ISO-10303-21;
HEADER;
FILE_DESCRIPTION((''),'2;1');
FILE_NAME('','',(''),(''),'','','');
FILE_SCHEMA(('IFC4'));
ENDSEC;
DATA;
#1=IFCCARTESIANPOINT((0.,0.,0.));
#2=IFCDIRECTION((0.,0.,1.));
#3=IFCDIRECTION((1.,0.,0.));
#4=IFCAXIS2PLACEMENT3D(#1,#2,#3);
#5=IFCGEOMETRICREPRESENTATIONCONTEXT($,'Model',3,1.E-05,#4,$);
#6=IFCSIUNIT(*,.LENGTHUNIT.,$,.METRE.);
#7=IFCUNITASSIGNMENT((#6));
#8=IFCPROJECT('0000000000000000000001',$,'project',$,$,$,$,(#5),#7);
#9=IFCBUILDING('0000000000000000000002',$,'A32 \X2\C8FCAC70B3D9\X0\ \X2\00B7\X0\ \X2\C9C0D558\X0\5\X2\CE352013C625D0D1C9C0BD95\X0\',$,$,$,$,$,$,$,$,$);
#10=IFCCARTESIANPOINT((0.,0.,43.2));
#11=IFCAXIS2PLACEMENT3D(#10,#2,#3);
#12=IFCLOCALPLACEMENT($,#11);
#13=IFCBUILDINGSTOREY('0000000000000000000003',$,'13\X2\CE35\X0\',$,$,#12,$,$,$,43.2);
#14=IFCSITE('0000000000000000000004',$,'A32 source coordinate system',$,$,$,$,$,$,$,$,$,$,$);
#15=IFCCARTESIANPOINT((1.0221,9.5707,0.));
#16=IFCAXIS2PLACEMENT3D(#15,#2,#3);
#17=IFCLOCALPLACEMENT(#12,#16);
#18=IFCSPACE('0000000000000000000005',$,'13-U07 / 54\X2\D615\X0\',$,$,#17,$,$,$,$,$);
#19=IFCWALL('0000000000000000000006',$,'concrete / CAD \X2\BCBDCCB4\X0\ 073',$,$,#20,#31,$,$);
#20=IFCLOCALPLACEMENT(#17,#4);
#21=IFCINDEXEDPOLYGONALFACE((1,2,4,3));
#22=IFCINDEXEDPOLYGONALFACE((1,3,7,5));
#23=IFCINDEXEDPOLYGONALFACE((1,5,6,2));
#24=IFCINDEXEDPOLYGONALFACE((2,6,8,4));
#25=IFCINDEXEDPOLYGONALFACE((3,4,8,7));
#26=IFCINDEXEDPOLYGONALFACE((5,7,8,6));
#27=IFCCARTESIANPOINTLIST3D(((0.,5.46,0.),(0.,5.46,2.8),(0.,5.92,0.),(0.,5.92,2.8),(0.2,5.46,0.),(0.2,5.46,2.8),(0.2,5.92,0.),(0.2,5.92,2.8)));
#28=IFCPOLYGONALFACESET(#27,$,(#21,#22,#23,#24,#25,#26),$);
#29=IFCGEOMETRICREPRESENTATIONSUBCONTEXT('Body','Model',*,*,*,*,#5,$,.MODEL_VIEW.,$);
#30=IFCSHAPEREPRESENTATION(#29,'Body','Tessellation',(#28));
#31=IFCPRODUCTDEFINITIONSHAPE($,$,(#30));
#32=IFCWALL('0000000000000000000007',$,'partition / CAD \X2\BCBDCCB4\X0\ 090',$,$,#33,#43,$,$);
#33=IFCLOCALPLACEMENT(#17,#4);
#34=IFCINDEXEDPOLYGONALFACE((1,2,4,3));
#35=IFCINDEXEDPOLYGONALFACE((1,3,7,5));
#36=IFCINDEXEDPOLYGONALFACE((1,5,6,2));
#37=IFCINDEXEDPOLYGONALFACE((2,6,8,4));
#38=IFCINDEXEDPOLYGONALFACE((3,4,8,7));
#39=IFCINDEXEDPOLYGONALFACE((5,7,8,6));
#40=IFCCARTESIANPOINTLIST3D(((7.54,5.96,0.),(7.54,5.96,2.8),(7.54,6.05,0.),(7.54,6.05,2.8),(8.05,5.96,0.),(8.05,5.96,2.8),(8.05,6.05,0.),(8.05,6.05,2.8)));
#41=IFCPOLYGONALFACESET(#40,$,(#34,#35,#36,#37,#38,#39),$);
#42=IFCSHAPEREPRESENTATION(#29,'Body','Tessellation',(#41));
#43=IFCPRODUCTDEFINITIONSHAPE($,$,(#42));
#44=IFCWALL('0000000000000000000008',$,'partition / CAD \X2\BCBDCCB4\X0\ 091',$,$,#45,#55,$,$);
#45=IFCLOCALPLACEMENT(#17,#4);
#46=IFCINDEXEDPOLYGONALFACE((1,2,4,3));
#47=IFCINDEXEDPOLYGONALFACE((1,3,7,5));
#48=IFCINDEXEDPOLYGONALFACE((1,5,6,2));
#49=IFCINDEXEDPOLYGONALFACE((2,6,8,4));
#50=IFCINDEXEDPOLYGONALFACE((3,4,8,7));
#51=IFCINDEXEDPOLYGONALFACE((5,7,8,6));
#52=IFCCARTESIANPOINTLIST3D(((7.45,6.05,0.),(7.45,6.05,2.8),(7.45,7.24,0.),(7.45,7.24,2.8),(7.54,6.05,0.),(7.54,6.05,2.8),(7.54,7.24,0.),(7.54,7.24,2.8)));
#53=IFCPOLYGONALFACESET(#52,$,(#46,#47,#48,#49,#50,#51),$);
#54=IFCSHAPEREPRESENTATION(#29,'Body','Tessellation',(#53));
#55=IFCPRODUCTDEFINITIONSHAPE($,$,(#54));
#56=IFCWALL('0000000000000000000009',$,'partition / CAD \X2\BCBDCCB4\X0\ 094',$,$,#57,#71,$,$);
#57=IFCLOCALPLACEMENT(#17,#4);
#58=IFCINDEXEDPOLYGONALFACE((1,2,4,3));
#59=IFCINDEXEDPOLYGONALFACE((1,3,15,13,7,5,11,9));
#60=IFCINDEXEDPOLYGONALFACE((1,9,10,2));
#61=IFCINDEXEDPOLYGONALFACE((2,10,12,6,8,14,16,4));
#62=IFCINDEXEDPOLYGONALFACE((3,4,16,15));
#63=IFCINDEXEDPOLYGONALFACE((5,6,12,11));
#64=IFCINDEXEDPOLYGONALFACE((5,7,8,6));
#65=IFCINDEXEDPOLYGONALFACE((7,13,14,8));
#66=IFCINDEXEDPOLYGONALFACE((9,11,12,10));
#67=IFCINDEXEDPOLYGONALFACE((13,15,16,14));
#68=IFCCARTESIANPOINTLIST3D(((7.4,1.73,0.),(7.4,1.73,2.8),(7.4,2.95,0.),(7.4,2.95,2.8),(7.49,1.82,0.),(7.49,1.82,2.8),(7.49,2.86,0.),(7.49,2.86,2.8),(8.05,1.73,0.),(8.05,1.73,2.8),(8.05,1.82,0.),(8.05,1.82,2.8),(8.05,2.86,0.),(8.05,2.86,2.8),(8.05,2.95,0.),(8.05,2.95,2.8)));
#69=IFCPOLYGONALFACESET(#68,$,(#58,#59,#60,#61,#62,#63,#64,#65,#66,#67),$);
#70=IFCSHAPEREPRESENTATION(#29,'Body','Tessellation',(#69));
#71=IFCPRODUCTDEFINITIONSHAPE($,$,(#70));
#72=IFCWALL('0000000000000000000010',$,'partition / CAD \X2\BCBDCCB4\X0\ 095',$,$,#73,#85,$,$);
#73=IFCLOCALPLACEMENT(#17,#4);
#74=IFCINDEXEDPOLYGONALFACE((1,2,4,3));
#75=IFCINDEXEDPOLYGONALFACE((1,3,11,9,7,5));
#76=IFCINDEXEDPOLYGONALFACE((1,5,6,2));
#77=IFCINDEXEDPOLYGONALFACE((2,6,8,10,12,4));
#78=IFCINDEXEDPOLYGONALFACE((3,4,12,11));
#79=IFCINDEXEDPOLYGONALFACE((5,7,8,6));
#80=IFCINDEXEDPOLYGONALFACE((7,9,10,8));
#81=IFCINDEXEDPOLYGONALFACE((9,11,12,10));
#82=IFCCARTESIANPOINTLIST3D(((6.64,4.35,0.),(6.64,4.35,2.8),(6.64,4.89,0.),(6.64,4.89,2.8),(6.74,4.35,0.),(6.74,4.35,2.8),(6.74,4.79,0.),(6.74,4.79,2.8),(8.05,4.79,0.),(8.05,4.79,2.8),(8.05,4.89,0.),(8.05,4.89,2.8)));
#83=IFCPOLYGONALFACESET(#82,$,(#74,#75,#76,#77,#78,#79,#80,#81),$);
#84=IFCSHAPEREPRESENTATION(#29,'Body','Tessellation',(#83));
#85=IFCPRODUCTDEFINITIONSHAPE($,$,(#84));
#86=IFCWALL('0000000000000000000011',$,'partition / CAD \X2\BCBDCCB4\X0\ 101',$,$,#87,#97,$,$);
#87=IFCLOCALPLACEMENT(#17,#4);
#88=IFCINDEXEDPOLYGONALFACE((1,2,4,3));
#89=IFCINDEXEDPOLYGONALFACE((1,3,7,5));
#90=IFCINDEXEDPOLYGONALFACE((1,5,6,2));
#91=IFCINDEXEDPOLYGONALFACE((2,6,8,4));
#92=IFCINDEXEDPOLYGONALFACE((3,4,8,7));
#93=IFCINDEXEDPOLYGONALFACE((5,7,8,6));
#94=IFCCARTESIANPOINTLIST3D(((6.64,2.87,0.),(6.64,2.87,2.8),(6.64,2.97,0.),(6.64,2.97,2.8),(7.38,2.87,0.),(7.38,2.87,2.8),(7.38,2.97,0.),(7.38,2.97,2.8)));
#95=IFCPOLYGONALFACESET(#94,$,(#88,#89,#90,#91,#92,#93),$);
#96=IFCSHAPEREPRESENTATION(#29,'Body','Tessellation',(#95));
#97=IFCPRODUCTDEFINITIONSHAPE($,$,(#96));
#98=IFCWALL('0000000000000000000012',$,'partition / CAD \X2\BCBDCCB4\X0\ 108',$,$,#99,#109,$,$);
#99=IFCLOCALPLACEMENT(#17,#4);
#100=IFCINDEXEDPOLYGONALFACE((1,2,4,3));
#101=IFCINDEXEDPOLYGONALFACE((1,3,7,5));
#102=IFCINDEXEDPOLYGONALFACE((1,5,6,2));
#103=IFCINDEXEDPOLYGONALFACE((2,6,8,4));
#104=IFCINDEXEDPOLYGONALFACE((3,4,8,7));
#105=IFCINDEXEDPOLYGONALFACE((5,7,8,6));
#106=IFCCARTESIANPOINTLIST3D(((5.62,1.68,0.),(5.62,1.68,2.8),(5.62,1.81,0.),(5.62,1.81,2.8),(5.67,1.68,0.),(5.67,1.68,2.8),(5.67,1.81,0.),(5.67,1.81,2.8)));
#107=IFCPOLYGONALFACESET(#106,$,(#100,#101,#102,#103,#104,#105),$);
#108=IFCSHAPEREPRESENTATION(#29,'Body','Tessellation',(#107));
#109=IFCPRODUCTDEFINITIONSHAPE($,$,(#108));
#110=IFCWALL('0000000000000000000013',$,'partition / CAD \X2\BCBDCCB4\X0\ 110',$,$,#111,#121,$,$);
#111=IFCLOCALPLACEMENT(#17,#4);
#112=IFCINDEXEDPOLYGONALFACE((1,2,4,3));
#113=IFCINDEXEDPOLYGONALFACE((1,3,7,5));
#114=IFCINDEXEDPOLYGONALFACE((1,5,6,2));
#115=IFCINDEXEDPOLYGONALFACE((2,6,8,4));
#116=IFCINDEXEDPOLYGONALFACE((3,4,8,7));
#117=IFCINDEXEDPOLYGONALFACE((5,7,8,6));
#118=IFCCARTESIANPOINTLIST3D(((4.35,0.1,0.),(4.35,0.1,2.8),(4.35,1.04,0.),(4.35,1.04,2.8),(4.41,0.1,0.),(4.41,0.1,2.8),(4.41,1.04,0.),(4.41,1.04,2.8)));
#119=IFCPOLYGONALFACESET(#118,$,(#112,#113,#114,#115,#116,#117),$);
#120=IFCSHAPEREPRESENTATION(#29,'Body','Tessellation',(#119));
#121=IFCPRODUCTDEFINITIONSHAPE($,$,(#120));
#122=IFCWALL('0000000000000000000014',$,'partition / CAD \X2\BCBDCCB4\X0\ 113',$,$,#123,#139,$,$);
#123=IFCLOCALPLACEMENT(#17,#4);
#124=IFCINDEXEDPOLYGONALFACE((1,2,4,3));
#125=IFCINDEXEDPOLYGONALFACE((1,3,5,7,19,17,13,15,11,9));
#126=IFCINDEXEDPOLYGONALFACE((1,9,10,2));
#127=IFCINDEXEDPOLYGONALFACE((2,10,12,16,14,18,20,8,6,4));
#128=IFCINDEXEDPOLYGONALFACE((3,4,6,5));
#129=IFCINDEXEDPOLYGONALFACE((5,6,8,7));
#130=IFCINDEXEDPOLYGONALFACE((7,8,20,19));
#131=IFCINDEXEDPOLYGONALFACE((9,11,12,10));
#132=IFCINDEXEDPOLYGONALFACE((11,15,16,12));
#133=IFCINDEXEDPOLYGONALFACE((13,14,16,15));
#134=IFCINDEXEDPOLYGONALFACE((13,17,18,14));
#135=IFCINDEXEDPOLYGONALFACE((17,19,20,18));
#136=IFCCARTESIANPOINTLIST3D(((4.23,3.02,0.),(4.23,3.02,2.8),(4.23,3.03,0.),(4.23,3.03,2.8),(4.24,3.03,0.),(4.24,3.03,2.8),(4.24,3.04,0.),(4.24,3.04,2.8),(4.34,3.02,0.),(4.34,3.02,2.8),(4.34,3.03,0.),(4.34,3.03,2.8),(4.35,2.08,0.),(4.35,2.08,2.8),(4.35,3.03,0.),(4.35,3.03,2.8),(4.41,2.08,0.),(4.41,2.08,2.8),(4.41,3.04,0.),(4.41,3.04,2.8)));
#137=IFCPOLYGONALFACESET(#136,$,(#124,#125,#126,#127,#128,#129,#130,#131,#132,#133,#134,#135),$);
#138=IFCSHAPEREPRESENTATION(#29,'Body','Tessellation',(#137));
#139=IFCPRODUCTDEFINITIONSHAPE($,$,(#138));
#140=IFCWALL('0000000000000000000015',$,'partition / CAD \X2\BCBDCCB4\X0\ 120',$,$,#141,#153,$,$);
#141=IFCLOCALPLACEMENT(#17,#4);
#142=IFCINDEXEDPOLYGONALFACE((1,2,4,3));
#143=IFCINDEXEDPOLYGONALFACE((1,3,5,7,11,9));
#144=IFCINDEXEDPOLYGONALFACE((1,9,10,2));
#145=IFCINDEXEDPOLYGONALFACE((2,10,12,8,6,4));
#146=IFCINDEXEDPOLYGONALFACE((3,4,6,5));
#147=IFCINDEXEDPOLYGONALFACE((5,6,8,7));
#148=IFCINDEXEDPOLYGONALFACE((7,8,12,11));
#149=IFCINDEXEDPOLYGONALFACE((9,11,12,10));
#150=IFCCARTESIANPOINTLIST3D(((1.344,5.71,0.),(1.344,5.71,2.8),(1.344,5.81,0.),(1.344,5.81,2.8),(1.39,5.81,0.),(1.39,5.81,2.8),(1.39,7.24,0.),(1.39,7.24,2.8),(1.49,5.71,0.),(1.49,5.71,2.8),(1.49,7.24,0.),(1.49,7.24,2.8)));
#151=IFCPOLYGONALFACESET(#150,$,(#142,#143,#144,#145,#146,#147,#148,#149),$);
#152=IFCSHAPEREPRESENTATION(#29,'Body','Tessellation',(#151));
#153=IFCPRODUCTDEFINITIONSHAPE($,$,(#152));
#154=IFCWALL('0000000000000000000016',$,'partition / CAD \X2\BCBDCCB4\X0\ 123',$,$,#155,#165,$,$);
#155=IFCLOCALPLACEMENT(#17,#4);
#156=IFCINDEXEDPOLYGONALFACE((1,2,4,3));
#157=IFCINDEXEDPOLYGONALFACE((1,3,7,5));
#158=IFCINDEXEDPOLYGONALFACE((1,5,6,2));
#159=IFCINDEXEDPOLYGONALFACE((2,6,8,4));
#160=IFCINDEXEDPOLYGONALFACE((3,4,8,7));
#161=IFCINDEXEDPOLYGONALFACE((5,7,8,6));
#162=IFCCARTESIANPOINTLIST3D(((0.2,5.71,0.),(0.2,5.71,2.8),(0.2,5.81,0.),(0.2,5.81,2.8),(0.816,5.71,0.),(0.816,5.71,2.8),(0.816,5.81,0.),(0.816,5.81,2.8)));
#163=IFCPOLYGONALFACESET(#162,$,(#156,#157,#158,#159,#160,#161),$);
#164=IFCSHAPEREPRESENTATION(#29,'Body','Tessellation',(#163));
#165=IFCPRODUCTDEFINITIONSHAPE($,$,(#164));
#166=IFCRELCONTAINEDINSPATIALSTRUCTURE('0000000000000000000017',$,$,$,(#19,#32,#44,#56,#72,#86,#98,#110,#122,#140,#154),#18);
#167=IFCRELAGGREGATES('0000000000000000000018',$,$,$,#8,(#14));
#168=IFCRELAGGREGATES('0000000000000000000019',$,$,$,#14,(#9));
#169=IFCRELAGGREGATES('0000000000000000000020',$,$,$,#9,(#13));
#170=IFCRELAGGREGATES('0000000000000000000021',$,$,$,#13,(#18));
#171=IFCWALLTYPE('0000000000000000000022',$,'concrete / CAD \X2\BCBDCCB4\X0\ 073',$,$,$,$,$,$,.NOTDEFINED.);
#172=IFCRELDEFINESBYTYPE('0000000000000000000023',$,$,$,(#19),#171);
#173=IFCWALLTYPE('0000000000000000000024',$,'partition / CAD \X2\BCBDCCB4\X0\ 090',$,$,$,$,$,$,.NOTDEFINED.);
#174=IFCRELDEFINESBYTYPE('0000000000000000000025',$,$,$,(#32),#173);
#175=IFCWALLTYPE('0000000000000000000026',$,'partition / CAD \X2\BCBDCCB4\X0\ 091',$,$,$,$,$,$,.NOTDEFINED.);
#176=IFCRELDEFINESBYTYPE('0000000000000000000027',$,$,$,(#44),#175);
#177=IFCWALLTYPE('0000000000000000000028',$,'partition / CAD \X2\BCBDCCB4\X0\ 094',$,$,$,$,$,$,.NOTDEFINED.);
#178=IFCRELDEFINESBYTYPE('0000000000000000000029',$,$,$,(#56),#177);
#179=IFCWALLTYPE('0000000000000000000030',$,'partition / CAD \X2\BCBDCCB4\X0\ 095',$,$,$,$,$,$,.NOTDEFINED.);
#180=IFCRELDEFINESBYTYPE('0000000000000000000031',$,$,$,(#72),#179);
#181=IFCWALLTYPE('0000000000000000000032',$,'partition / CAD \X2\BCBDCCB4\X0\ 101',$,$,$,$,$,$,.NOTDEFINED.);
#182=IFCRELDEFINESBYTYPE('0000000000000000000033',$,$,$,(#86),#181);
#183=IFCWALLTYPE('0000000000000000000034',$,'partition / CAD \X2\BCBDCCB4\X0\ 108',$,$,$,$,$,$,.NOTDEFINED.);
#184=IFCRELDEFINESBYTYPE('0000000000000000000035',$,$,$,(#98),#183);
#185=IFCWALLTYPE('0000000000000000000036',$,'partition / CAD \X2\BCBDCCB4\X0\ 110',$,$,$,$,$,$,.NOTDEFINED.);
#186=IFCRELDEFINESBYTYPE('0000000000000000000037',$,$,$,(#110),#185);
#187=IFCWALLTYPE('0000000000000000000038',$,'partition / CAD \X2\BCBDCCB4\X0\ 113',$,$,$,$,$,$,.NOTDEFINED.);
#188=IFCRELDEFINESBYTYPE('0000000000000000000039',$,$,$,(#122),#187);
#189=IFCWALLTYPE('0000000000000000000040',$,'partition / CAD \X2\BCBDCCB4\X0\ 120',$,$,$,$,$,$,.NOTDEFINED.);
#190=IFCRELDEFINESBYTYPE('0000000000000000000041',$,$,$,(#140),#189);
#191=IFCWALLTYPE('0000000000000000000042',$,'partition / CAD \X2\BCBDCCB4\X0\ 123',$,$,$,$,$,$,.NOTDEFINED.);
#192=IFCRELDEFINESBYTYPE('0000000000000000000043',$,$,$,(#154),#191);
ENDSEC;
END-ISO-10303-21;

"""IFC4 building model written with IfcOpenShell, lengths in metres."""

from ifc_helpers import new_model, si_unit, frame, origin, origin_with_axes, place, context, subcontext, project, spatial, polyline, outline, extrude, source, transform, mapped, type_object, type_shapes, element, save


model = new_model("IFC4")

# Units and contexts
model_context = context("Model", 3, precision=1e-05, world=origin_with_axes())
body_context = subcontext(model_context, "Body", "Model", "MODEL_VIEW")
ifc_project = project(units=[si_unit("LENGTHUNIT", "METRE")], contexts=[model_context])

# Site, building, storey, space
site = spatial("IfcSite", under=ifc_project, Name="A32 source coordinate system")
building = spatial("IfcBuilding", under=site, Name="A32 주거동 · 지하5층–옥탑지붕")
storey_placement = place(None, frame((0.0, 0.0, 43.2), z_axis=(0.0, 0.0, 1.0), x_axis=(1.0, 0.0, 0.0)))
storey = spatial("IfcBuildingStorey", under=building, at=storey_placement, Name="13층", Elevation=43.2)
space_1_placement = place(storey_placement, frame((1.0221, 9.5707, 0.0), z_axis=(0.0, 0.0, 1.0), x_axis=(1.0, 0.0, 0.0)))
space_1 = spatial("IfcSpace", under=storey, at=space_1_placement, Name="13-U07 / 54형")

# Walls
wall_type_1 = type_object("IfcWallType", Name="concrete / CAD 벽체 073", PredefinedType="NOTDEFINED")
shared_shape_1 = source(origin(), body_context, "Body", "SweptSolid", [
    extrude(outline(polyline([(0.2, 5.92), (0.2, 5.46), (0.0, 5.46), (0.0, 5.92), (0.2, 5.92)])), origin(), (0.0, 0.0, 1.0), 2.8),
])
type_shapes(wall_type_1, [shared_shape_1])
wall_1_placement = place(space_1_placement, origin_with_axes())
element("IfcWall", 1, at=wall_1_placement, inside=space_1, type_object=wall_type_1, Name="concrete / CAD 벽체 073", context=body_context, shape_type="MappedRepresentation", body=[
    mapped(shared_shape_1, transform((0.0, 0.0, 0.0), scale=1.0)),
])
wall_type_2 = type_object("IfcWallType", Name="partition / CAD 벽체 090", PredefinedType="NOTDEFINED")
shared_shape_2 = source(origin(), body_context, "Body", "SweptSolid", [
    extrude(outline(polyline([(7.54, 5.96), (7.54, 6.05), (8.05, 6.05), (8.05, 5.96), (7.54, 5.96)])), origin(), (0.0, 0.0, 1.0), 2.8),
])
type_shapes(wall_type_2, [shared_shape_2])
wall_2_placement = place(space_1_placement, origin_with_axes())
element("IfcWall", 2, at=wall_2_placement, inside=space_1, type_object=wall_type_2, Name="partition / CAD 벽체 090", context=body_context, shape_type="MappedRepresentation", body=[
    mapped(shared_shape_2, transform((0.0, 0.0, 0.0), scale=1.0)),
])
wall_type_3 = type_object("IfcWallType", Name="partition / CAD 벽체 091", PredefinedType="NOTDEFINED")
shared_shape_3 = source(origin(), body_context, "Body", "SweptSolid", [
    extrude(outline(polyline([(7.54, 6.05), (7.45, 6.05), (7.45, 7.24), (7.54, 7.24), (7.54, 6.05)])), origin(), (0.0, 0.0, 1.0), 2.8),
])
type_shapes(wall_type_3, [shared_shape_3])
wall_3_placement = place(space_1_placement, origin_with_axes())
element("IfcWall", 3, at=wall_3_placement, inside=space_1, type_object=wall_type_3, Name="partition / CAD 벽체 091", context=body_context, shape_type="MappedRepresentation", body=[
    mapped(shared_shape_3, transform((0.0, 0.0, 0.0), scale=1.0)),
])
wall_type_4 = type_object("IfcWallType", Name="partition / CAD 벽체 094", PredefinedType="NOTDEFINED")
shared_shape_4 = source(origin(), body_context, "Body", "SweptSolid", [
    extrude(outline(polyline([(8.05, 1.73), (7.4, 1.73), (7.4, 2.95), (8.05, 2.95), (8.05, 2.86), (7.49, 2.86), (7.49, 1.82), (8.05, 1.82), (8.05, 1.73)])), origin(), (0.0, 0.0, 1.0), 2.8),
])
type_shapes(wall_type_4, [shared_shape_4])
wall_4_placement = place(space_1_placement, origin_with_axes())
element("IfcWall", 4, at=wall_4_placement, inside=space_1, type_object=wall_type_4, Name="partition / CAD 벽체 094", context=body_context, shape_type="MappedRepresentation", body=[
    mapped(shared_shape_4, transform((0.0, 0.0, 0.0), scale=1.0)),
])
wall_type_5 = type_object("IfcWallType", Name="partition / CAD 벽체 095", PredefinedType="NOTDEFINED")
shared_shape_5 = source(origin(), body_context, "Body", "SweptSolid", [
    extrude(outline(polyline([(6.64, 4.89), (8.05, 4.89), (8.05, 4.79), (6.74, 4.79), (6.74, 4.35), (6.64, 4.35), (6.64, 4.89)])), origin(), (0.0, 0.0, 1.0), 2.8),
])
type_shapes(wall_type_5, [shared_shape_5])
wall_5_placement = place(space_1_placement, origin_with_axes())
element("IfcWall", 5, at=wall_5_placement, inside=space_1, type_object=wall_type_5, Name="partition / CAD 벽체 095", context=body_context, shape_type="MappedRepresentation", body=[
    mapped(shared_shape_5, transform((0.0, 0.0, 0.0), scale=1.0)),
])
wall_type_6 = type_object("IfcWallType", Name="partition / CAD 벽체 101", PredefinedType="NOTDEFINED")
shared_shape_6 = source(origin(), body_context, "Body", "SweptSolid", [
    extrude(outline(polyline([(7.38, 2.97), (7.38, 2.87), (6.64, 2.87), (6.64, 2.97), (7.38, 2.97)])), origin(), (0.0, 0.0, 1.0), 2.8),
])
type_shapes(wall_type_6, [shared_shape_6])
wall_6_placement = place(space_1_placement, origin_with_axes())
element("IfcWall", 6, at=wall_6_placement, inside=space_1, type_object=wall_type_6, Name="partition / CAD 벽체 101", context=body_context, shape_type="MappedRepresentation", body=[
    mapped(shared_shape_6, transform((0.0, 0.0, 0.0), scale=1.0)),
])
wall_type_7 = type_object("IfcWallType", Name="partition / CAD 벽체 108", PredefinedType="NOTDEFINED")
shared_shape_7 = source(origin(), body_context, "Body", "SweptSolid", [
    extrude(outline(polyline([(5.67, 1.68), (5.62, 1.68), (5.62, 1.81), (5.67, 1.81), (5.67, 1.68)])), origin(), (0.0, 0.0, 1.0), 2.8),
])
type_shapes(wall_type_7, [shared_shape_7])
wall_7_placement = place(space_1_placement, origin_with_axes())
element("IfcWall", 7, at=wall_7_placement, inside=space_1, type_object=wall_type_7, Name="partition / CAD 벽체 108", context=body_context, shape_type="MappedRepresentation", body=[
    mapped(shared_shape_7, transform((0.0, 0.0, 0.0), scale=1.0)),
])
wall_type_8 = type_object("IfcWallType", Name="partition / CAD 벽체 110", PredefinedType="NOTDEFINED")
shared_shape_8 = source(origin(), body_context, "Body", "SweptSolid", [
    extrude(outline(polyline([(4.35, 1.04), (4.41, 1.04), (4.41, 0.1), (4.35, 0.1), (4.35, 1.04)])), origin(), (0.0, 0.0, 1.0), 2.8),
])
type_shapes(wall_type_8, [shared_shape_8])
wall_8_placement = place(space_1_placement, origin_with_axes())
element("IfcWall", 8, at=wall_8_placement, inside=space_1, type_object=wall_type_8, Name="partition / CAD 벽체 110", context=body_context, shape_type="MappedRepresentation", body=[
    mapped(shared_shape_8, transform((0.0, 0.0, 0.0), scale=1.0)),
])
wall_type_9 = type_object("IfcWallType", Name="partition / CAD 벽체 113", PredefinedType="NOTDEFINED")
shared_shape_9 = source(origin(), body_context, "Body", "SweptSolid", [
    extrude(outline(polyline([(4.24, 3.04), (4.41, 3.04), (4.41, 2.08), (4.35, 2.08), (4.35, 3.03), (4.34, 3.03), (4.34, 3.02), (4.23, 3.02), (4.23, 3.03), (4.24, 3.03), (4.24, 3.04)])), origin(), (0.0, 0.0, 1.0), 2.8),
])
type_shapes(wall_type_9, [shared_shape_9])
wall_9_placement = place(space_1_placement, origin_with_axes())
element("IfcWall", 9, at=wall_9_placement, inside=space_1, type_object=wall_type_9, Name="partition / CAD 벽체 113", context=body_context, shape_type="MappedRepresentation", body=[
    mapped(shared_shape_9, transform((0.0, 0.0, 0.0), scale=1.0)),
])
wall_type_10 = type_object("IfcWallType", Name="partition / CAD 벽체 120", PredefinedType="NOTDEFINED")
shared_shape_10 = source(origin(), body_context, "Body", "SweptSolid", [
    extrude(outline(polyline([(1.39, 7.24), (1.49, 7.24), (1.49, 5.71), (1.344, 5.71), (1.344, 5.81), (1.39, 5.81), (1.39, 7.24)])), origin(), (0.0, 0.0, 1.0), 2.8),
])
type_shapes(wall_type_10, [shared_shape_10])
wall_10_placement = place(space_1_placement, origin_with_axes())
element("IfcWall", 10, at=wall_10_placement, inside=space_1, type_object=wall_type_10, Name="partition / CAD 벽체 120", context=body_context, shape_type="MappedRepresentation", body=[
    mapped(shared_shape_10, transform((0.0, 0.0, 0.0), scale=1.0)),
])
wall_type_11 = type_object("IfcWallType", Name="partition / CAD 벽체 123", PredefinedType="NOTDEFINED")
shared_shape_11 = source(origin(), body_context, "Body", "SweptSolid", [
    extrude(outline(polyline([(0.816, 5.81), (0.816, 5.71), (0.2, 5.71), (0.2, 5.81), (0.816, 5.81)])), origin(), (0.0, 0.0, 1.0), 2.8),
])
type_shapes(wall_type_11, [shared_shape_11])
wall_11_placement = place(space_1_placement, origin_with_axes())
element("IfcWall", 11, at=wall_11_placement, inside=space_1, type_object=wall_type_11, Name="partition / CAD 벽체 123", context=body_context, shape_type="MappedRepresentation", body=[
    mapped(shared_shape_11, transform((0.0, 0.0, 0.0), scale=1.0)),
])

save(model, "model.ifc")
